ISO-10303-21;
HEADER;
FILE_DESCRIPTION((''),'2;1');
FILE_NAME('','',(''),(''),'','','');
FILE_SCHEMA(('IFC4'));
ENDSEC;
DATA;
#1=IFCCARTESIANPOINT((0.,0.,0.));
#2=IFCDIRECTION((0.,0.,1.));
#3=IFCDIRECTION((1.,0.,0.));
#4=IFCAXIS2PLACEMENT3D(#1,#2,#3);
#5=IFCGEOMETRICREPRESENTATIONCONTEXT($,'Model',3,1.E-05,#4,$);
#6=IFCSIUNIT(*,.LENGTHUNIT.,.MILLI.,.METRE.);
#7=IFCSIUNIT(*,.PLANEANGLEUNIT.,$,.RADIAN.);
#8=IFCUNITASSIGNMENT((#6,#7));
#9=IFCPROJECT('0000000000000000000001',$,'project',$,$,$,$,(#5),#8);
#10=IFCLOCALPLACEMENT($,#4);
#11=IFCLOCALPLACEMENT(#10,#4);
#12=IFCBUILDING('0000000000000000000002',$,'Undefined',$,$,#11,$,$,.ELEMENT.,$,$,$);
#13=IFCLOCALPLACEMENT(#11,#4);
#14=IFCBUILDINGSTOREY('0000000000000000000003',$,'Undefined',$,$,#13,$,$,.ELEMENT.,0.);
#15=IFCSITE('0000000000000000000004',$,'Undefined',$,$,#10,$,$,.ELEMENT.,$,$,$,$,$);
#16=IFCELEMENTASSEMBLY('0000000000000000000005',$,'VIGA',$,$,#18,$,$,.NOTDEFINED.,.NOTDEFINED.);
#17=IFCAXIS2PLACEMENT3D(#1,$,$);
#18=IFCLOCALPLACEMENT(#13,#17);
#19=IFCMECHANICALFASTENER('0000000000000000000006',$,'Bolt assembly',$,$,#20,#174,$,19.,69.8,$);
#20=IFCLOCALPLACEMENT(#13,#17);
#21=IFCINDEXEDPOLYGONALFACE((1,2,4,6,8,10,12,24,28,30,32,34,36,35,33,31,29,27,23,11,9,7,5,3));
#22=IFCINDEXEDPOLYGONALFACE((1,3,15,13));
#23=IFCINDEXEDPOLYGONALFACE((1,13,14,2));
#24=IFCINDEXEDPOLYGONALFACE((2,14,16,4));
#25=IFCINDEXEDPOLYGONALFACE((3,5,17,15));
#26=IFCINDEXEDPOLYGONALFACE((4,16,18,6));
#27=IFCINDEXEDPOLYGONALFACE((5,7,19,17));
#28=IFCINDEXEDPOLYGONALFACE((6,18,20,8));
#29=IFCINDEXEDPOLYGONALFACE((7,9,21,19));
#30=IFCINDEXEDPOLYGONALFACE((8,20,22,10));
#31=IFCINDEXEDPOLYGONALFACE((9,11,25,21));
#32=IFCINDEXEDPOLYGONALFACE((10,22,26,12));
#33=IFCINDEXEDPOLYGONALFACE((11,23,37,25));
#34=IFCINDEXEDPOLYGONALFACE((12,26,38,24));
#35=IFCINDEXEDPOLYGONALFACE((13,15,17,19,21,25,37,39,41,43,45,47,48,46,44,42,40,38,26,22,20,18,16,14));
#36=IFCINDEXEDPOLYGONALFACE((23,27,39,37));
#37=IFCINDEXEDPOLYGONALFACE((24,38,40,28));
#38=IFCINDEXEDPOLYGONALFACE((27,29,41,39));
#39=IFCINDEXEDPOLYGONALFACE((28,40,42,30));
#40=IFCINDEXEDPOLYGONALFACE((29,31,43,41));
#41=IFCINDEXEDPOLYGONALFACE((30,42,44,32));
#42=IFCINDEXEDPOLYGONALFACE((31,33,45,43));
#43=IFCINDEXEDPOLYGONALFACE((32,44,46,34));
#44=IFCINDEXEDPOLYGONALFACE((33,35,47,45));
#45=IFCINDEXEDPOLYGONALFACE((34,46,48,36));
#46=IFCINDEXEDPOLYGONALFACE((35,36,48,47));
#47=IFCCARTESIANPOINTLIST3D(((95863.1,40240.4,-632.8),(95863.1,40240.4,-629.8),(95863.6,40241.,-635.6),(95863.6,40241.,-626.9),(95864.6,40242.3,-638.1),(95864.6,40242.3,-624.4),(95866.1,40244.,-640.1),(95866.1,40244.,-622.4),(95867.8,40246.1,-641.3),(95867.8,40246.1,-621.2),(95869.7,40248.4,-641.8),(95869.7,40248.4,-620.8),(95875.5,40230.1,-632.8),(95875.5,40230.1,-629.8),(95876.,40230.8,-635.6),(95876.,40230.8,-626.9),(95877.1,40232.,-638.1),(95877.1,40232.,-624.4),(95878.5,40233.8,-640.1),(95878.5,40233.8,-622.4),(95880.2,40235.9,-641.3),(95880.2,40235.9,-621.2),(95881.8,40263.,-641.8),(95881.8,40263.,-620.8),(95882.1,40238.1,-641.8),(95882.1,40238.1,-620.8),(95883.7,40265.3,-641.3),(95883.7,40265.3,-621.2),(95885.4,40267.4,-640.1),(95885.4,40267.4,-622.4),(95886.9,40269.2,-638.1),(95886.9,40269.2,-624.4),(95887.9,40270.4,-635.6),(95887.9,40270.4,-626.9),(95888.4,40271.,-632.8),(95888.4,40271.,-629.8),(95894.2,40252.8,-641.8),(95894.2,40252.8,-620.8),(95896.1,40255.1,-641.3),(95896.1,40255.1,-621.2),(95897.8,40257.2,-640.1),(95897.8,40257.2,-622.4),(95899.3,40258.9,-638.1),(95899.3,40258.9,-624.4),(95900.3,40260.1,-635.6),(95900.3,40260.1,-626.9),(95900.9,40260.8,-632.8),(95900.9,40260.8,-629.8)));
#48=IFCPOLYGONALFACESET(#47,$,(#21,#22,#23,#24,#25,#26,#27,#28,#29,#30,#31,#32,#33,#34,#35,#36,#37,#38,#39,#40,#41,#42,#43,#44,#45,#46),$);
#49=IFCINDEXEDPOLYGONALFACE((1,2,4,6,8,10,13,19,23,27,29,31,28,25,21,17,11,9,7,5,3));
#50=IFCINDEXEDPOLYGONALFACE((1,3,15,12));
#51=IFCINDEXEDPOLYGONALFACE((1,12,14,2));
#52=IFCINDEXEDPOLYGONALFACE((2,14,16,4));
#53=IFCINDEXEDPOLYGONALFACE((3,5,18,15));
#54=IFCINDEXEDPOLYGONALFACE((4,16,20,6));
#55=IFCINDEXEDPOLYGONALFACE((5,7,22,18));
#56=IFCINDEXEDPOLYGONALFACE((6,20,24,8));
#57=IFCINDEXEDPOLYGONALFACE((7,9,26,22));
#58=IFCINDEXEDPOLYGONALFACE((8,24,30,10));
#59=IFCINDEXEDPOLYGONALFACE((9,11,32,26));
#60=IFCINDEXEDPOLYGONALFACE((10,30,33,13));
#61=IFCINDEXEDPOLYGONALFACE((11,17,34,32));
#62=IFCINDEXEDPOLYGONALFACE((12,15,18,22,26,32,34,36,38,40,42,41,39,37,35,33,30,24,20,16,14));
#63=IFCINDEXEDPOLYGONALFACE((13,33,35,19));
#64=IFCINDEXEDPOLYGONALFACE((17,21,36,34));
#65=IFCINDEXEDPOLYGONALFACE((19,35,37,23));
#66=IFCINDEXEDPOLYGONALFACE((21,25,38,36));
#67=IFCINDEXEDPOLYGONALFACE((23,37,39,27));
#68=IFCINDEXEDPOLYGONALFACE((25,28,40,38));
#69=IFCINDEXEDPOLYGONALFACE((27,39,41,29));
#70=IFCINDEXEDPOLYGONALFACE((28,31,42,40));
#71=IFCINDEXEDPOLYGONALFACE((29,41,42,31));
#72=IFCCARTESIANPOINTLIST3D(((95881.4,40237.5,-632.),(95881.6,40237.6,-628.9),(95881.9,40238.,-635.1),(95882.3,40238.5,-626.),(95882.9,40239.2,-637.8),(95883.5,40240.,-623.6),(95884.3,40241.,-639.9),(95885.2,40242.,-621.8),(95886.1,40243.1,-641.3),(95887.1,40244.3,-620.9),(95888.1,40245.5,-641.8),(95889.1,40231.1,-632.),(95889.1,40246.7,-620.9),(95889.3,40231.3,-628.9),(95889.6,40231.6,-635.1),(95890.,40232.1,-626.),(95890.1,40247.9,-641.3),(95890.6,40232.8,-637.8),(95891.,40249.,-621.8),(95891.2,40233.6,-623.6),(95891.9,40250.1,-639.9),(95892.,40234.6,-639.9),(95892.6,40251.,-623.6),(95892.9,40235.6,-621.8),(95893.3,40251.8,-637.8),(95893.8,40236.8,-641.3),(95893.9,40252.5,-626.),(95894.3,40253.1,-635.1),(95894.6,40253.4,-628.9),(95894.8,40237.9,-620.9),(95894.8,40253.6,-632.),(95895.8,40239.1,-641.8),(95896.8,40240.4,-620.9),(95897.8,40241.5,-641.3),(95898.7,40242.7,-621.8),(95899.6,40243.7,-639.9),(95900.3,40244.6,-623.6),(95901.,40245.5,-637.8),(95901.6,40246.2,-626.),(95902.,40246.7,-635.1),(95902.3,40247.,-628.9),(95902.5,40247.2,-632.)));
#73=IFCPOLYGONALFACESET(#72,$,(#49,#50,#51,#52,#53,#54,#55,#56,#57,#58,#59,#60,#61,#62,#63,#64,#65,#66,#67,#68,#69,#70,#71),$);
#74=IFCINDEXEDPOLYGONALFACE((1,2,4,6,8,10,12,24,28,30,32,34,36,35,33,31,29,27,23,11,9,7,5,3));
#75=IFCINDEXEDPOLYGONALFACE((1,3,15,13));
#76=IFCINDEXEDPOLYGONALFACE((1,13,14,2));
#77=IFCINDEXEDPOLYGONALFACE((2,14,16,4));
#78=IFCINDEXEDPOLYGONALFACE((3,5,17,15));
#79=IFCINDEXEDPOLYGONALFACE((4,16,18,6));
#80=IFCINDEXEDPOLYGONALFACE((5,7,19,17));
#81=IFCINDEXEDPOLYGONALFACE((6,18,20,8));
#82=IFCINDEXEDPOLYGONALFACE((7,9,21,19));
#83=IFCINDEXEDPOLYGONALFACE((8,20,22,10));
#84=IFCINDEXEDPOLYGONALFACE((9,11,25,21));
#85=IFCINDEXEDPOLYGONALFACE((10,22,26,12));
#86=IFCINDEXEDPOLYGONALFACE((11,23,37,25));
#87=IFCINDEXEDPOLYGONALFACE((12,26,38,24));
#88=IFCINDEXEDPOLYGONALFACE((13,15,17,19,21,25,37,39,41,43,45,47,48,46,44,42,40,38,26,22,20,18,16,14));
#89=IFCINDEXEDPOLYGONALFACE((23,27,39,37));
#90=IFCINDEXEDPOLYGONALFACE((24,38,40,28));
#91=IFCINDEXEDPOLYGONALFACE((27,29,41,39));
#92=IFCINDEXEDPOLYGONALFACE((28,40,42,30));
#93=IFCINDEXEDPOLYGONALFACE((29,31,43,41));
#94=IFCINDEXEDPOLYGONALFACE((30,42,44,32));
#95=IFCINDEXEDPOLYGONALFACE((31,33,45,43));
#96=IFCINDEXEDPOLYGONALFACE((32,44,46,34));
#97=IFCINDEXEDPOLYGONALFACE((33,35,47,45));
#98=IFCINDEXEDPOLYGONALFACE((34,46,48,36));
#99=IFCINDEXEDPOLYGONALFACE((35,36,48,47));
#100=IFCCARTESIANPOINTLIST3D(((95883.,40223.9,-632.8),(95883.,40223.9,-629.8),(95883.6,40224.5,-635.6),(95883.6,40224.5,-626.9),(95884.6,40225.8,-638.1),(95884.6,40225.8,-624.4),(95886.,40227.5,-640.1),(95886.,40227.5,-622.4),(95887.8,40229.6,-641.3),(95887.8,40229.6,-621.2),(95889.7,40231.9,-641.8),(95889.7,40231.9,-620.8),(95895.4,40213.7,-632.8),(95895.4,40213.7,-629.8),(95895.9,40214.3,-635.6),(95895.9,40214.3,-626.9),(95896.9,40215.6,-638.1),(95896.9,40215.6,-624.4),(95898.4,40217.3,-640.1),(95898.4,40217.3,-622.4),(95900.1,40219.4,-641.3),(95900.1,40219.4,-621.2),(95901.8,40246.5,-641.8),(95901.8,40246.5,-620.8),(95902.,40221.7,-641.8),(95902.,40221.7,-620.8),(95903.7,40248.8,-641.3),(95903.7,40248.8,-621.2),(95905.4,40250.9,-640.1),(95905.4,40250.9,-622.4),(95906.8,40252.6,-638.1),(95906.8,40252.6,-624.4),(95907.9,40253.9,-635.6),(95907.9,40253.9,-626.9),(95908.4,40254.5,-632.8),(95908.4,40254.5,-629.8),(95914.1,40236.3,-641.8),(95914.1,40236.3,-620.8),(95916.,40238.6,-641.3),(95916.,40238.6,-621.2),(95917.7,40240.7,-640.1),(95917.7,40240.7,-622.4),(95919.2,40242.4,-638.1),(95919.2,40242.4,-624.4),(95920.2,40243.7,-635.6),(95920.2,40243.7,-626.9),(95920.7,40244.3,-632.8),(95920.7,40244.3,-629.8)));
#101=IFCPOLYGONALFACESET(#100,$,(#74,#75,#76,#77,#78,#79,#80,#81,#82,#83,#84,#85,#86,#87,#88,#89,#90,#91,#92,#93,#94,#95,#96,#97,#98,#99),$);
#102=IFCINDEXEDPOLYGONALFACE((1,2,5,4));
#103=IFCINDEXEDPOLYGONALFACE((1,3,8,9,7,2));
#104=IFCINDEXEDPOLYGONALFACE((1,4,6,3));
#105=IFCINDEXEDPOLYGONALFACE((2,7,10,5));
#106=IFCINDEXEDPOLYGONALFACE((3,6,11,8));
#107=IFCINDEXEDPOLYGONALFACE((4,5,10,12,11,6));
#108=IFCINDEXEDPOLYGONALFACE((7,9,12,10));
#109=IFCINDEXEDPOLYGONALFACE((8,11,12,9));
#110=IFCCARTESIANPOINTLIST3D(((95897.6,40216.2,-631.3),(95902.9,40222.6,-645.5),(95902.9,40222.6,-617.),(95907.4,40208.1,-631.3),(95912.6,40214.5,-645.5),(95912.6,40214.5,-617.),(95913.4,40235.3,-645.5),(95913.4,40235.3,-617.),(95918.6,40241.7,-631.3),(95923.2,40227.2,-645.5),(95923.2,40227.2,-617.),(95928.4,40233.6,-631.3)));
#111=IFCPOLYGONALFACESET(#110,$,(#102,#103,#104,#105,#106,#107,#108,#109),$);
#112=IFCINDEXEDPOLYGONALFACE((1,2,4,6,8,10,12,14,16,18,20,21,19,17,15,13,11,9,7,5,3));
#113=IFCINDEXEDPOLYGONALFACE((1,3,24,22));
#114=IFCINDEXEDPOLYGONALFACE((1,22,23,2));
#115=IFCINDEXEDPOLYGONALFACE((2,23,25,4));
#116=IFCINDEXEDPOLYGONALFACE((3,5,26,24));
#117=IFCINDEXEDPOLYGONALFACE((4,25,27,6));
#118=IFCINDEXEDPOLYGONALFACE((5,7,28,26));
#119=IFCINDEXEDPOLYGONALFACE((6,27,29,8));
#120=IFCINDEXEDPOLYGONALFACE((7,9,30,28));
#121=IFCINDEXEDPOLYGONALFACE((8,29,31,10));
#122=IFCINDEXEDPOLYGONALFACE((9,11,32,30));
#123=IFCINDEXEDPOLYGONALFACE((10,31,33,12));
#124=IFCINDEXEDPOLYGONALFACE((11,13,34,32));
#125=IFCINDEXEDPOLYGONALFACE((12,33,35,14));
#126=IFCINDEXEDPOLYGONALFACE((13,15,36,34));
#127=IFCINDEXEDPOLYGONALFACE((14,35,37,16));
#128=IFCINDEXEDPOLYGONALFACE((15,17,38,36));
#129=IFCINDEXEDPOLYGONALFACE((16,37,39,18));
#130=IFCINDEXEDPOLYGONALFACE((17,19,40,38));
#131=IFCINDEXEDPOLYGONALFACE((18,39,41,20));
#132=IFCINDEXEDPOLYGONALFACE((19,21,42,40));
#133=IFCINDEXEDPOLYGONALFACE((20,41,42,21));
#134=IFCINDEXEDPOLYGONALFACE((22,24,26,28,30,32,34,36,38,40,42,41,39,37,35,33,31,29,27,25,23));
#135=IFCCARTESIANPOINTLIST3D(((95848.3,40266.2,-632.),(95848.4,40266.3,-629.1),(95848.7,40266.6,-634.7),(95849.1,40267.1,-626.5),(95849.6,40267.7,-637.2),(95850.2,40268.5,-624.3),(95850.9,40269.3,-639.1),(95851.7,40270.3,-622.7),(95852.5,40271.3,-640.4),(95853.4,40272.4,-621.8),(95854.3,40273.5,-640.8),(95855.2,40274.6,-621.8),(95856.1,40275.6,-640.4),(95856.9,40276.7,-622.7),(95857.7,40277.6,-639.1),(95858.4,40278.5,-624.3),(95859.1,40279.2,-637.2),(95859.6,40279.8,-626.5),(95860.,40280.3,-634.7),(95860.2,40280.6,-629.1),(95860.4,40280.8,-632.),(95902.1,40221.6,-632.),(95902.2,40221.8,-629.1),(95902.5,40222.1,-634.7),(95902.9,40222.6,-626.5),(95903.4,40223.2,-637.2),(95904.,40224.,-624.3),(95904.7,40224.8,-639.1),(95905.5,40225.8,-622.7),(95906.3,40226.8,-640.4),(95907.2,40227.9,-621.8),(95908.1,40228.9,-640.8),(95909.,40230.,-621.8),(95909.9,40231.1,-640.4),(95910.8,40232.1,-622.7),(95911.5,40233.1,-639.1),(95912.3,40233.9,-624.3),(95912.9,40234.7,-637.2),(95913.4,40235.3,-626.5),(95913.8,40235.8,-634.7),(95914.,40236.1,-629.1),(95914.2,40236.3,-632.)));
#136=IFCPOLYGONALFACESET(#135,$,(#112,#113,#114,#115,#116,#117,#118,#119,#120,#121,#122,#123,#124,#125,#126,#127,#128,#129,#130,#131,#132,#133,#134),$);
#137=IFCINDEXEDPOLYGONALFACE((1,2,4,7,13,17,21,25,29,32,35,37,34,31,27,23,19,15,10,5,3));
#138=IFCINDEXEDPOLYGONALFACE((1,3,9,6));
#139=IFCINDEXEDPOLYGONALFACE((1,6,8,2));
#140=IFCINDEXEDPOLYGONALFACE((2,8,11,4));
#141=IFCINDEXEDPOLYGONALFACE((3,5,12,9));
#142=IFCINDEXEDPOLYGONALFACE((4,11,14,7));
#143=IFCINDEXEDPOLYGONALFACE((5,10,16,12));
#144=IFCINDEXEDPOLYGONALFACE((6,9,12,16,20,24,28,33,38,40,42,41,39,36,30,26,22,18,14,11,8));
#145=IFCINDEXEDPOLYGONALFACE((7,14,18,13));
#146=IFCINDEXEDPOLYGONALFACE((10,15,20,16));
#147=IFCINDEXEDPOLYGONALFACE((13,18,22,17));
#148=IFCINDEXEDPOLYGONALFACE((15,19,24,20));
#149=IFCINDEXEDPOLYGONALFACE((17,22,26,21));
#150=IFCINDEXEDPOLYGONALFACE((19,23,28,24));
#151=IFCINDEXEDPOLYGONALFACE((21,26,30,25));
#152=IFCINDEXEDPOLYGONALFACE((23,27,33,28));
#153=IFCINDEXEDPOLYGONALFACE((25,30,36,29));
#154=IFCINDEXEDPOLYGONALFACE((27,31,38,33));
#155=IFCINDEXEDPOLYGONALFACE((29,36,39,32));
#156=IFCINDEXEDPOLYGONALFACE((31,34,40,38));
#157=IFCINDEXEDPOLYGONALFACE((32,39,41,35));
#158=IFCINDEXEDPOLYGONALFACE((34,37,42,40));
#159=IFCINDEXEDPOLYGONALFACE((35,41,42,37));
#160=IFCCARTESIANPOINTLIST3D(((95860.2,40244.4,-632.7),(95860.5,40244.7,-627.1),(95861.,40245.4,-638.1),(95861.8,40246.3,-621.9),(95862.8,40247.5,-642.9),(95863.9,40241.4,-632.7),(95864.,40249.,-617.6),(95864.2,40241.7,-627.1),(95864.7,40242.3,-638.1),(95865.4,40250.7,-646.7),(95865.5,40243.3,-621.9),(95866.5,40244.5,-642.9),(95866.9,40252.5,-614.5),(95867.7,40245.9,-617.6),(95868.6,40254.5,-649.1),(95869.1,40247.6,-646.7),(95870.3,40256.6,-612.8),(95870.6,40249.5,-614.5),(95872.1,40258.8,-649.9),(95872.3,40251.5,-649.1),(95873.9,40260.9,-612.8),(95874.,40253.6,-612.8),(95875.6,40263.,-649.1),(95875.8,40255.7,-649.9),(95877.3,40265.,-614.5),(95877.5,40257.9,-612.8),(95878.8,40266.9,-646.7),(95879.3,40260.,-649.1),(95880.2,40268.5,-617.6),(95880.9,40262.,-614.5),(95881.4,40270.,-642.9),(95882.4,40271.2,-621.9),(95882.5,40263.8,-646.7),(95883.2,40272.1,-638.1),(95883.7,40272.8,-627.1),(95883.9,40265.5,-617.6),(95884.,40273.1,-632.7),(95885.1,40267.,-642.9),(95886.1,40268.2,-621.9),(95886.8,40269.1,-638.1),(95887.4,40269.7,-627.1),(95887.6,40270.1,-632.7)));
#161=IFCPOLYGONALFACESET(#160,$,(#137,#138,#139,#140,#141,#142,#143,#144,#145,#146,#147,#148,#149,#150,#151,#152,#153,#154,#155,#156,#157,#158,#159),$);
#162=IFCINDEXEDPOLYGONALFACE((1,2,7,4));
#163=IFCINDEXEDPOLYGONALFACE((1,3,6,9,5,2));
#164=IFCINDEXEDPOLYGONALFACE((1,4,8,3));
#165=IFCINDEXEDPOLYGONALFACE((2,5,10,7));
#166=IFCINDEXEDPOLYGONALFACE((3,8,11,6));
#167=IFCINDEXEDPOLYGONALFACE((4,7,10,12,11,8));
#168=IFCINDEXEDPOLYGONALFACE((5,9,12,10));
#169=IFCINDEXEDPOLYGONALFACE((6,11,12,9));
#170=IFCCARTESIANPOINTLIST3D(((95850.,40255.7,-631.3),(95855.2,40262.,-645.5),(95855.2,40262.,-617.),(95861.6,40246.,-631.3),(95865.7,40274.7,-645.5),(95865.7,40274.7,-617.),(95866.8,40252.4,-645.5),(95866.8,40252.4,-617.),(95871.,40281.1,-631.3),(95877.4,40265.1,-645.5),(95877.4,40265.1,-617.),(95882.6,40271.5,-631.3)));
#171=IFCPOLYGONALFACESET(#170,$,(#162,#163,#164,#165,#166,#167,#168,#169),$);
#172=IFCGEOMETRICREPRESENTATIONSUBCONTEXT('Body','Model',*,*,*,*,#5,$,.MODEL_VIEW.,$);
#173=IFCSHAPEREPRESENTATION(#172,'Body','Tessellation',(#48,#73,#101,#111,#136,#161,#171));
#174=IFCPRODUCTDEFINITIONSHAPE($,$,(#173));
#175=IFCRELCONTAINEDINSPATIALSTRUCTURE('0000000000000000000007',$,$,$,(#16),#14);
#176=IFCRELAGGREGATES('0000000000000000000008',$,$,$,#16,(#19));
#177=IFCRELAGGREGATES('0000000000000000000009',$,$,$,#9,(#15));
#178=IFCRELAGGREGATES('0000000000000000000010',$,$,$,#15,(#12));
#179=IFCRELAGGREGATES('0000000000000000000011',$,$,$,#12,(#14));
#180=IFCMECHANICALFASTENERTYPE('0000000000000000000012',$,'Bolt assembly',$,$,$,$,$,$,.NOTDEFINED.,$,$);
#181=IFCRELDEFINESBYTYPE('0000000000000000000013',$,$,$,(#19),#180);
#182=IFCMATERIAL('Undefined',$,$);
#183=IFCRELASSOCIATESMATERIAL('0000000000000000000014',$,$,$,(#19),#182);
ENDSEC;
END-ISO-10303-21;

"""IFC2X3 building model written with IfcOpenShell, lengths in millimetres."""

from ifc_helpers import new_model, entity, si_unit, frame, origin_with_axes, origin_2d_with_axis, place, context, subcontext, project, spatial, polyline, circle, outline, extrude, source, transform, mapped, material, type_object, element, aggregate, save


model = new_model("IFC2X3")

# Units and contexts
model_context = context("Model", 3, precision=1e-05, world=origin_with_axes())
body_context = subcontext(model_context, "Body", "Model", "MODEL_VIEW")
ifc_project = project(units=[si_unit("LENGTHUNIT", "METRE", prefix="MILLI"), si_unit("PLANEANGLEUNIT", "RADIAN")], contexts=[model_context])

# Site, building, storey
site_placement = place(None, origin_with_axes())
site = spatial("IfcSite", under=ifc_project, at=site_placement, Name="Undefined", CompositionType="ELEMENT")
building_placement = place(site_placement, origin_with_axes())
building = spatial("IfcBuilding", under=site, at=building_placement, Name="Undefined", CompositionType="ELEMENT")
storey_placement = place(building_placement, origin_with_axes())
storey = spatial("IfcBuildingStorey", under=building, at=storey_placement, Name="Undefined", CompositionType="ELEMENT", Elevation=0.0)

# Element assembly
assembly_1_placement = place(storey_placement, origin_with_axes())
assembly_1 = element("IfcElementAssembly", 1, at=assembly_1_placement, inside=storey, Name="VIGA", AssemblyPlace="NOTDEFINED", PredefinedType="NOTDEFINED")

# Mechanical fastener
ifc_material_1 = material(Name="Undefined")
mechanical_fastener_type = type_object("IfcMechanicalFastenerType", Name="Bolt assembly")
shared_circle_1 = entity("IfcCircle", entity("IfcAxis2Placement2D", entity("IfcCartesianPoint", [0.0, -9.5]), entity("IfcDirection", [1.0, 0.0])), 10.5)
shared_circle_2 = entity("IfcCircle", entity("IfcAxis2Placement2D", entity("IfcCartesianPoint", [0.0, 9.5]), entity("IfcDirection", [-1.0, 0.0])), 10.5)
shared_composite_curve = entity("IfcCompositeCurve", [entity("IfcCompositeCurveSegment", "CONTINUOUS", True, entity("IfcPolyline", [entity("IfcCartesianPoint", [10.5, 9.5]), entity("IfcCartesianPoint", [10.5, -9.5])])), entity("IfcCompositeCurveSegment", "CONTINUOUS", True, entity("IfcTrimmedCurve", shared_circle_1, [entity("IfcParameterValue", 0.0)], [entity("IfcParameterValue", 3.141593)], False, "PARAMETER")), entity("IfcCompositeCurveSegment", "CONTINUOUS", True, entity("IfcPolyline", [entity("IfcCartesianPoint", [-10.5, -9.5]), entity("IfcCartesianPoint", [-10.5, 9.5])])), entity("IfcCompositeCurveSegment", "DISCONTINUOUS", True, entity("IfcTrimmedCurve", shared_circle_2, [entity("IfcParameterValue", 0.0)], [entity("IfcParameterValue", 3.141593)], False, "PARAMETER"))], False)
shared_shape_1 = source(origin_with_axes(), body_context, "Body", "SweptSolid", [
    entity("IfcExtrudedAreaSolid", entity("IfcArbitraryClosedProfileDef", "AREA", None, shared_composite_curve), entity("IfcAxis2Placement3D", entity("IfcCartesianPoint", [0.0, 4.9, 0.0]), entity("IfcDirection", [0.0, 1.0, 0.0]), entity("IfcDirection", [1.0, 0.0, 0.0])), entity("IfcDirection", [0.0, 0.0, 1.0]), 16.1),
    extrude(circle(Radius=10.5, at=origin_2d_with_axis()), frame((0.0, -5.0, 0.0), z_axis=(0.0, 1.0, 0.0), x_axis=(1.0, 0.0, 0.0)), (0.0, 0.0, 1.0), 10.0),
    entity("IfcExtrudedAreaSolid", entity("IfcArbitraryClosedProfileDef", "AREA", None, shared_composite_curve), entity("IfcAxis2Placement3D", entity("IfcCartesianPoint", [0.0, -20.9, 0.0]), entity("IfcDirection", [0.0, 1.0, 0.0]), entity("IfcDirection", [1.0, 0.0, 0.0])), entity("IfcDirection", [0.0, 0.0, 1.0]), 16.0),
    extrude(outline(polyline([(14.3, -8.2), (14.3, 8.2), (0.0, 16.5), (-14.3, 8.2), (-14.3, -8.2), (0.0, -16.5), (14.3, -8.2)])), frame((0.0, -33.7, 0.0), z_axis=(0.0, 1.0, 0.0), x_axis=(1.0, 0.0, 0.0)), (0.0, 0.0, 1.0), 12.7),
    extrude(circle(Radius=9.5, at=origin_2d_with_axis()), frame((0.0, -21.0, 0.0), z_axis=(0.0, 1.0, 0.0), x_axis=(1.0, 0.0, 0.0)), (0.0, 0.0, 1.0), 69.8),
    extrude(circle(Radius=18.7, at=origin_2d_with_axis()), frame((0.0, 21.0, 0.0), z_axis=(0.0, 1.0, 0.0), x_axis=(1.0, 0.0, 0.0)), (0.0, 0.0, 1.0), 4.8),
    extrude(outline(polyline([(14.3, -8.2), (14.3, 8.2), (0.0, 16.5), (-14.3, 8.2), (-14.3, -8.2), (0.0, -16.5), (14.3, -8.2)])), frame((0.0, 25.8, 0.0), z_axis=(0.0, 1.0, 0.0), x_axis=(1.0, 0.0, 0.0)), (0.0, 0.0, 1.0), 15.1),
])
mechanical_fastener_1_placement = place(assembly_1_placement, frame((95828.2, 40165.3, -631.3), z_axis=(0.63756, 0.770401, 0.0), x_axis=(0.0, 0.0, -1.0)))
mechanical_fastener_1 = element("IfcMechanicalFastener", 2, at=mechanical_fastener_1_placement, type_object=mechanical_fastener_type, material=ifc_material_1, Name="Bolt assembly", NominalDiameter=19.0, NominalLength=69.8, context=body_context, shape_type="MappedRepresentation", body=[
    mapped(shared_shape_1, transform((0.0, 0.0, 100.0))),
])

aggregate(assembly_1, [mechanical_fastener_1])

save(model, "model.ifc")
